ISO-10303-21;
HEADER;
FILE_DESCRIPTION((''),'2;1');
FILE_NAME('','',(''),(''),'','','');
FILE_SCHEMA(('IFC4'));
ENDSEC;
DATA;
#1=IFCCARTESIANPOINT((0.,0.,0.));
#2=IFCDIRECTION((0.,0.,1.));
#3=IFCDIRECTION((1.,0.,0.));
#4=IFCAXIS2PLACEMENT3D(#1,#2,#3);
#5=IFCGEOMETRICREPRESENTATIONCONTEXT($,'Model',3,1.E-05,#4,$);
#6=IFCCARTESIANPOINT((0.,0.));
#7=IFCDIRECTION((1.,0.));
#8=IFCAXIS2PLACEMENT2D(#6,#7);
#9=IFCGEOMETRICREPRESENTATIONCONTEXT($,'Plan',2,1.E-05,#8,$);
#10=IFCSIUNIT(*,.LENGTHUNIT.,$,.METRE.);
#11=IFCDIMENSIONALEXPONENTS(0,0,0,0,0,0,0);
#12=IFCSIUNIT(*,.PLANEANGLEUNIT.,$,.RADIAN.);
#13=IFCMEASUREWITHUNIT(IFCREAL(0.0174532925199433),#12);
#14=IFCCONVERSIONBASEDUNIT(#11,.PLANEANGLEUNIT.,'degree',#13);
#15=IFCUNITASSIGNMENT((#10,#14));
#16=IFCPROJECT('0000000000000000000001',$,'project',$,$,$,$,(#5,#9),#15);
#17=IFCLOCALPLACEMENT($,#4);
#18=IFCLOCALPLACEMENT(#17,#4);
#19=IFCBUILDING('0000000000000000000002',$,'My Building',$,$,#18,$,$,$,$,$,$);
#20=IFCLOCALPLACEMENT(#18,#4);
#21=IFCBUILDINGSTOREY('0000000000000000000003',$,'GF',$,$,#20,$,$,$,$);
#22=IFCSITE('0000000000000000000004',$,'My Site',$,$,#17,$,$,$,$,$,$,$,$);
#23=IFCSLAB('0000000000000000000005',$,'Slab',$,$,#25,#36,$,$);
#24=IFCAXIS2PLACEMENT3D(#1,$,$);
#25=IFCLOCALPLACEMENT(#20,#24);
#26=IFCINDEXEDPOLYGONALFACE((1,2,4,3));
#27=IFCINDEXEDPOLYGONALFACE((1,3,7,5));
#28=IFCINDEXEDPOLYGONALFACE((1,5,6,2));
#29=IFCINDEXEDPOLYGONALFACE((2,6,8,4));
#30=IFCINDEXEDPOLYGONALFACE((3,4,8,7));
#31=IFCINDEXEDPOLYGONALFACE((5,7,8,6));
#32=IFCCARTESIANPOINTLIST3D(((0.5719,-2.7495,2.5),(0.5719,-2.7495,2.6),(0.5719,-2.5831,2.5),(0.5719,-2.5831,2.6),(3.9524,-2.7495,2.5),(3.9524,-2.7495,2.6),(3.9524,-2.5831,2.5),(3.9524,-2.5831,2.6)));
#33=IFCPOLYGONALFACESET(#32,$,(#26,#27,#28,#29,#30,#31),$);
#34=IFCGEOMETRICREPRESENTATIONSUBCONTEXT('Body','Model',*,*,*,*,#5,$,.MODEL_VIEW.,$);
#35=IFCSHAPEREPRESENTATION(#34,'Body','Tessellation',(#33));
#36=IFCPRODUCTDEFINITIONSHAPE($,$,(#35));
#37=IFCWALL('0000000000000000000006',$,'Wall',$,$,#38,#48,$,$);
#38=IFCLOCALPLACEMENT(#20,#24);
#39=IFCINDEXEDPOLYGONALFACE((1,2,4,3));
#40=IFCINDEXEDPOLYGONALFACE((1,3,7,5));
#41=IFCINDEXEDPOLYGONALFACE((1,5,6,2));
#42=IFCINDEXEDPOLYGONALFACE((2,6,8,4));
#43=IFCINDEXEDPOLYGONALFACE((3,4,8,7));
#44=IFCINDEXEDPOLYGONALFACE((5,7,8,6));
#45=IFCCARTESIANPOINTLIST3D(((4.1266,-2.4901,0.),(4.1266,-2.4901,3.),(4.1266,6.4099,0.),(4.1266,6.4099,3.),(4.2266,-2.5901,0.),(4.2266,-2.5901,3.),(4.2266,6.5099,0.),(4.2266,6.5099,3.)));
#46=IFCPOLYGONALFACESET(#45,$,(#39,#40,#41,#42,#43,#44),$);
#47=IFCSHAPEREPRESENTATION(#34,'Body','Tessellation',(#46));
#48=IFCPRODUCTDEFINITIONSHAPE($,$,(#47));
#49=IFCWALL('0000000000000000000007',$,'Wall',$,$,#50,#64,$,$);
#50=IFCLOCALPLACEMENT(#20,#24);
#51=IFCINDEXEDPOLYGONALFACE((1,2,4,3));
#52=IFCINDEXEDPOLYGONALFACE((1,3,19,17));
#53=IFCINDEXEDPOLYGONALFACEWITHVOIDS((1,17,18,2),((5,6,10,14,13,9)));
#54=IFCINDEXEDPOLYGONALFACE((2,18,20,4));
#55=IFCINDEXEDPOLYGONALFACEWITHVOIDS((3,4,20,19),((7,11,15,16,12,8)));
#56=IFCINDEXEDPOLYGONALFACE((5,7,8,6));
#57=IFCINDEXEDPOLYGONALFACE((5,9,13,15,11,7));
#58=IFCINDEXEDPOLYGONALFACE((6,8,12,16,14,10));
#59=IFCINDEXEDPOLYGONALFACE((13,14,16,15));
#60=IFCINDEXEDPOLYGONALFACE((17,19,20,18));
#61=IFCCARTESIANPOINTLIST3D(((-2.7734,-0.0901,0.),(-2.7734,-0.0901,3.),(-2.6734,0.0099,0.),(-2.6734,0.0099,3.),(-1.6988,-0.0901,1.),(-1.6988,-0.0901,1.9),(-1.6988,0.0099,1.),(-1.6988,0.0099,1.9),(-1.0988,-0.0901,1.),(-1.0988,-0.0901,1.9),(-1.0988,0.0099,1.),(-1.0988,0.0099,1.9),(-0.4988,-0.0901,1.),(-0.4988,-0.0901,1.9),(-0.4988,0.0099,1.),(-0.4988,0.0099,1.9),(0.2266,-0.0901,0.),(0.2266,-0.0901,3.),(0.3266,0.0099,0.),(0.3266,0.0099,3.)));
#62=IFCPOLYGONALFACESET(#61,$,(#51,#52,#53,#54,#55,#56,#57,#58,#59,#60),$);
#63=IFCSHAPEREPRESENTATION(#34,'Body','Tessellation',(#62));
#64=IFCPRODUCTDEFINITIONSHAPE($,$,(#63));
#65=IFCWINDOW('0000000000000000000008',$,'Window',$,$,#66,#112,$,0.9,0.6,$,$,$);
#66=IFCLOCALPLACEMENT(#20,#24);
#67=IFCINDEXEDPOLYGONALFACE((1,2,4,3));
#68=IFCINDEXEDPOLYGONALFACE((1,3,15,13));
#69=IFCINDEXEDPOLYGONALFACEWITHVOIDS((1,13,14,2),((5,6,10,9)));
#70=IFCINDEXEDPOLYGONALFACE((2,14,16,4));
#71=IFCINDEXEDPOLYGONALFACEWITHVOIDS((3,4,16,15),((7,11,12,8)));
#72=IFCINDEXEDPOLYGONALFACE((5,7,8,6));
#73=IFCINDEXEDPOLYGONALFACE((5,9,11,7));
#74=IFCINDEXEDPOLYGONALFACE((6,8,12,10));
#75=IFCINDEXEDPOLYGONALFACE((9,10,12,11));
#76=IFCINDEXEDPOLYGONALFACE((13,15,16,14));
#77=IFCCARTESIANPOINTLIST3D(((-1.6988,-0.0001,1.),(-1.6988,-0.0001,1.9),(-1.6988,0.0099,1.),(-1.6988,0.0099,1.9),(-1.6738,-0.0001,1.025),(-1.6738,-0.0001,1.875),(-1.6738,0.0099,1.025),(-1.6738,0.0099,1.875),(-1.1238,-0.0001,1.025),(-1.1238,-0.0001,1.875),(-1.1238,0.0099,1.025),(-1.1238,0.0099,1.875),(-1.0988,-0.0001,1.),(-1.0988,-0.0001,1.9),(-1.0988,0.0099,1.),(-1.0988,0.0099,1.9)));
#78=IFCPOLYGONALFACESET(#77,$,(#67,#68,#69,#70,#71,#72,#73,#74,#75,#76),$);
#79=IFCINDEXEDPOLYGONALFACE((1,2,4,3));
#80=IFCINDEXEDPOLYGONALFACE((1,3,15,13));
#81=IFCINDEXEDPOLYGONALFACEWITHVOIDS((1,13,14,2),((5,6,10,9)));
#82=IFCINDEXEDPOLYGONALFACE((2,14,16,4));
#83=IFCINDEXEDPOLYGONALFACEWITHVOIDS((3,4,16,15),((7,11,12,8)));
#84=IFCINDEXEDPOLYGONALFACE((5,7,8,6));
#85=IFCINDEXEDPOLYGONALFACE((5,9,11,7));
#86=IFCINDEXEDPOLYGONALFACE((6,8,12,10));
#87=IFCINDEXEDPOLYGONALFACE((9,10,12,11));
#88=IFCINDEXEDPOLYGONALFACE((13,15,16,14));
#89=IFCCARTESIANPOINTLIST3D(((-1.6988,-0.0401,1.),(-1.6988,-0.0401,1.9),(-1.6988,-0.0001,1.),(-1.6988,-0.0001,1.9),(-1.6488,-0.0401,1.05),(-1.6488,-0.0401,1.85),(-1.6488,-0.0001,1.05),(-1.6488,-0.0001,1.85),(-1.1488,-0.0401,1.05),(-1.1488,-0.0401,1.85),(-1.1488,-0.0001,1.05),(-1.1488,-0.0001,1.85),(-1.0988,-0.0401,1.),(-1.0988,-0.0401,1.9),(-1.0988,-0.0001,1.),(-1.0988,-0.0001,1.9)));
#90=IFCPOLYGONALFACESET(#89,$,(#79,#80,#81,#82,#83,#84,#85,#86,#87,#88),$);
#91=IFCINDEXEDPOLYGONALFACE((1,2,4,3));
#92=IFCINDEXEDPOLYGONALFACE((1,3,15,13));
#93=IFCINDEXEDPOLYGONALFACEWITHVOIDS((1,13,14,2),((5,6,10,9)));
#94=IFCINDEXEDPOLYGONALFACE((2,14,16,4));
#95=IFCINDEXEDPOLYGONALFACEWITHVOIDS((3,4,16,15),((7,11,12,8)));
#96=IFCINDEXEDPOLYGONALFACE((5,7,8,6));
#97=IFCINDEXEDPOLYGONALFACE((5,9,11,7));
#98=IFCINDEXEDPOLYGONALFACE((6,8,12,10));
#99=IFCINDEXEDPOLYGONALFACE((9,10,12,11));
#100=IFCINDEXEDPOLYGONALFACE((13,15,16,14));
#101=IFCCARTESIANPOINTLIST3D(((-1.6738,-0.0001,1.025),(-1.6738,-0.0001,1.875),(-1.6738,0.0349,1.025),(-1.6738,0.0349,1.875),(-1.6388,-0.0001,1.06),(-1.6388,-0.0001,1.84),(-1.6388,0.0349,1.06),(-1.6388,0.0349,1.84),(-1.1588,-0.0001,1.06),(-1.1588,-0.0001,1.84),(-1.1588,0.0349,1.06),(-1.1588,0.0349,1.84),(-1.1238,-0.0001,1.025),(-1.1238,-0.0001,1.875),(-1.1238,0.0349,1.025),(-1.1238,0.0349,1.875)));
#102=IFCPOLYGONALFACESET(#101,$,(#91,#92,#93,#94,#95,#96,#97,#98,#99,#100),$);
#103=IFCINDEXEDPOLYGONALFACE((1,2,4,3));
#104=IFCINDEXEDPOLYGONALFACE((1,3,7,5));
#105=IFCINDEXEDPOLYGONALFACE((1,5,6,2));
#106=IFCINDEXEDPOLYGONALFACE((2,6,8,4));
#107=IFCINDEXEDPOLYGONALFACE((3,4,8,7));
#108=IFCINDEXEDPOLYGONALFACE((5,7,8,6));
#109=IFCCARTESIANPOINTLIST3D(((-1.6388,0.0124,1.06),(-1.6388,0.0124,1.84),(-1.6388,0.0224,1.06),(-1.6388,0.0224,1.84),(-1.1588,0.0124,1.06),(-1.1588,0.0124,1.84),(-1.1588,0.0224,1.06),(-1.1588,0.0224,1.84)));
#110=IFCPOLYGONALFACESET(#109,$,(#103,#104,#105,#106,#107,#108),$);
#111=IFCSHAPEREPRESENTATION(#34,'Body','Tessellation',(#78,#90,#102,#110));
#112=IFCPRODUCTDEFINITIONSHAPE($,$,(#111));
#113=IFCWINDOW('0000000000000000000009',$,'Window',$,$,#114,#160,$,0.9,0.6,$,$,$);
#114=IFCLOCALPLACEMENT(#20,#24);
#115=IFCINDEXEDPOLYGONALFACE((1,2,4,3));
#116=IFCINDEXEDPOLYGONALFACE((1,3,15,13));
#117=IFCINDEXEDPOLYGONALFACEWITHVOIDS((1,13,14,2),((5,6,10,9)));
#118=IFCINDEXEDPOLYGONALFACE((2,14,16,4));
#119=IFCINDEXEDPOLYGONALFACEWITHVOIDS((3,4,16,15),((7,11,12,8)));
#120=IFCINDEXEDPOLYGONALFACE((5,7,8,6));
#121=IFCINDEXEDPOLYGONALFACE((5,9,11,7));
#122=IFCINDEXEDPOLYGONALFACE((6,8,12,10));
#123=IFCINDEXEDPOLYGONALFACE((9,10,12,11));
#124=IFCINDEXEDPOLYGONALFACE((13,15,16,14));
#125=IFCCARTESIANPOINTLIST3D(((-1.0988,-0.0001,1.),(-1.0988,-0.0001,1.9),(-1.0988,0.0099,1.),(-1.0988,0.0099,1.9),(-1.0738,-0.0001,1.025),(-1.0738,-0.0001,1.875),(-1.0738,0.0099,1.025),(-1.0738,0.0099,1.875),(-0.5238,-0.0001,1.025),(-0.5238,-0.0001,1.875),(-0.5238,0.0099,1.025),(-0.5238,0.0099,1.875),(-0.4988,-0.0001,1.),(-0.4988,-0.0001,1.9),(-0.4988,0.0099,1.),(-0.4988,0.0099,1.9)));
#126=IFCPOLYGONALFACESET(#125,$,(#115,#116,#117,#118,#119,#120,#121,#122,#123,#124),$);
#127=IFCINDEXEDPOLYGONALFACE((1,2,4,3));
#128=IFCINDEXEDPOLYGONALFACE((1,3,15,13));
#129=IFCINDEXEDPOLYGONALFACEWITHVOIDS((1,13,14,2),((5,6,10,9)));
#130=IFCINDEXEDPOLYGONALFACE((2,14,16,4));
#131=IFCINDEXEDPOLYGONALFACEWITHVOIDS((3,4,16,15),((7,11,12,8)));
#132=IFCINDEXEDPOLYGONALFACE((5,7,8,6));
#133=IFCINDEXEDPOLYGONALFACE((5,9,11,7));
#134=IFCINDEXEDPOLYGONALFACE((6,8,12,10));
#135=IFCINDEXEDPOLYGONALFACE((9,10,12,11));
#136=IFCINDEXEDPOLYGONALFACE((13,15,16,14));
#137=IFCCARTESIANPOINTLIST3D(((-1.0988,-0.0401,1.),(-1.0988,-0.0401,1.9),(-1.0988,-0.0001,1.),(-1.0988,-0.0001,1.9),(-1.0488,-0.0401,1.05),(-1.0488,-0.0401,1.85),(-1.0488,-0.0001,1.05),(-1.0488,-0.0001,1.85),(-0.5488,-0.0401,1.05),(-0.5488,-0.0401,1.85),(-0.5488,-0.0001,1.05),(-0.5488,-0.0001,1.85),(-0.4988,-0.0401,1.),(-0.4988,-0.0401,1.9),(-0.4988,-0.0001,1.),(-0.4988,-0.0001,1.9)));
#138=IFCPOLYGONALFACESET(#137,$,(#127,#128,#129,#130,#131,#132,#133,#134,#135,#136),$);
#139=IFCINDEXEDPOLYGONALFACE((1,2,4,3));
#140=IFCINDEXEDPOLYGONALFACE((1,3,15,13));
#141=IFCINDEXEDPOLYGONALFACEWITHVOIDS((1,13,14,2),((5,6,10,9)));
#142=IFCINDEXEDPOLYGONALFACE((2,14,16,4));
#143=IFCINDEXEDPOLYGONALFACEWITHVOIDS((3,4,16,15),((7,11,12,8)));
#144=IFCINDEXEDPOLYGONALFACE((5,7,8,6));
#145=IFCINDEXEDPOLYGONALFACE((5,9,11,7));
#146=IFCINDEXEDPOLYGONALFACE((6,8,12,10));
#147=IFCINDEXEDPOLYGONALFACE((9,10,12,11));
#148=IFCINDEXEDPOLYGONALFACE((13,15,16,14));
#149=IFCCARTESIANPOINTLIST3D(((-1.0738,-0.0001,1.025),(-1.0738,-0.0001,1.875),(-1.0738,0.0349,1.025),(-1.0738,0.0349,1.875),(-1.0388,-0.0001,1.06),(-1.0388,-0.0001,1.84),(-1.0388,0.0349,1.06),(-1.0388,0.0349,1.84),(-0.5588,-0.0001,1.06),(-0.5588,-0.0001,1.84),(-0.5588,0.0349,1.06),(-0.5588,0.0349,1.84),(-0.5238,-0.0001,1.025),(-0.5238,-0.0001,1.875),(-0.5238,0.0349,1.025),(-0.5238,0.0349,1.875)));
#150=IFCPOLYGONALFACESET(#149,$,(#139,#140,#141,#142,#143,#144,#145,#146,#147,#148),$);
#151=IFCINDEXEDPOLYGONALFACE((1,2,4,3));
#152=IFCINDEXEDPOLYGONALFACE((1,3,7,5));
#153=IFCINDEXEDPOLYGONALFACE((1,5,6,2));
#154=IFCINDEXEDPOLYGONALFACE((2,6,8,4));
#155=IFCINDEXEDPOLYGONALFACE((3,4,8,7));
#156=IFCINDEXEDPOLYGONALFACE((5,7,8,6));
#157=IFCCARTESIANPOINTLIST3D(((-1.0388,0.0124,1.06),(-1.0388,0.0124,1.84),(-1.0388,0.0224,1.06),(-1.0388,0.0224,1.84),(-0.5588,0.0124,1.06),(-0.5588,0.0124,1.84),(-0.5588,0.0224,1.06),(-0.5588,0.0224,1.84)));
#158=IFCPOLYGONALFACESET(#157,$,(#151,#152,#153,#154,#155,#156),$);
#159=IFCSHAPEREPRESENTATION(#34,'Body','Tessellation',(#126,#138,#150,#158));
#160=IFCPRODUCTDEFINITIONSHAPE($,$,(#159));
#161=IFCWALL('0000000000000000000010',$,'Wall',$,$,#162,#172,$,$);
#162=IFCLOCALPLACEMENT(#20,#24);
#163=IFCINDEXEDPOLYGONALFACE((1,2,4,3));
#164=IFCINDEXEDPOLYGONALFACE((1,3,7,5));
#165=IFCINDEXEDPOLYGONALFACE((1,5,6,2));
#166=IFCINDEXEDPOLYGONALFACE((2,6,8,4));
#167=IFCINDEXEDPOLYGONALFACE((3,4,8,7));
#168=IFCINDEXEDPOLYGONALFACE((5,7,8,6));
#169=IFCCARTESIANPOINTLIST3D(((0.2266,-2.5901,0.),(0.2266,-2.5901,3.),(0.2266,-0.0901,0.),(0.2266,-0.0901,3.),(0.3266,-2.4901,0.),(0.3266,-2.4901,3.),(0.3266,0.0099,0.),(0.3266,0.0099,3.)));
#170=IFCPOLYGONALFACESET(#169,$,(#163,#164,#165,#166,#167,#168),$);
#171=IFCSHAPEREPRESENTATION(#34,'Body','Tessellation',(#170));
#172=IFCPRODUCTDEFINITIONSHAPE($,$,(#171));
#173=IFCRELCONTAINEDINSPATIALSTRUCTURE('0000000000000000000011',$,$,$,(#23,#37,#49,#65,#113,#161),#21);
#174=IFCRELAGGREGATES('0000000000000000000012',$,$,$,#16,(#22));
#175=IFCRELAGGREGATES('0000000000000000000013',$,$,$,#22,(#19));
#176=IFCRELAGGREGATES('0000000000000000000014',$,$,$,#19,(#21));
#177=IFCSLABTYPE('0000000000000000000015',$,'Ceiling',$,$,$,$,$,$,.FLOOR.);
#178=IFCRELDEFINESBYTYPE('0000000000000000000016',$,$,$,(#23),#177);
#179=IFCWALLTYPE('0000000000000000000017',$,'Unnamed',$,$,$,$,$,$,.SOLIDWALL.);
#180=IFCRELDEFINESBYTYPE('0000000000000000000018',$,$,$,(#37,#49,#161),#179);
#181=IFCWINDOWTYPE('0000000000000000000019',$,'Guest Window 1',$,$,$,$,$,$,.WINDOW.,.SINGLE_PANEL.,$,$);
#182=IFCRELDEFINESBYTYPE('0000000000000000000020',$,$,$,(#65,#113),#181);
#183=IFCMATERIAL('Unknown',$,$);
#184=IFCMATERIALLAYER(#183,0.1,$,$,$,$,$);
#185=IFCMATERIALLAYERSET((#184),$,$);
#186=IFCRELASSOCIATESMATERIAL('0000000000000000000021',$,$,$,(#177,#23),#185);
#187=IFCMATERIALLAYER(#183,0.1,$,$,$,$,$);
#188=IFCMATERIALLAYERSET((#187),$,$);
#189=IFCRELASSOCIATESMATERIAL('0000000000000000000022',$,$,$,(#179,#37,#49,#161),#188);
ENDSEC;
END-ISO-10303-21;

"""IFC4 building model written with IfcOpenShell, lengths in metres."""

from ifc_helpers import new_model, entity, si_unit, converted_unit, frame, origin_with_axes, origin_2d_with_axis, place, context, subcontext, project, spatial, line, indexed_curve, outline, extrude, shape, source, transform, mapped, material, layer, layer_set, layer_usage, type_object, type_shapes, element, fill, save


model = new_model("IFC4")

# Units and contexts
model_context = context("Model", 3, precision=1e-05, world=origin_with_axes())
plan_context = context("Plan", 2, precision=1e-05, world=origin_2d_with_axis())
body_context_1 = subcontext(model_context, "Body", "Model", "MODEL_VIEW")
body_context_2 = subcontext(plan_context, "Body", "Plan", "PLAN_VIEW")
ifc_project = project(units=[si_unit("LENGTHUNIT", "METRE"), converted_unit("PLANEANGLEUNIT", "degree", entity("IfcReal", 0.0174532925199433), si_unit("PLANEANGLEUNIT", "RADIAN"), dimensions=[0, 0, 0, 0, 0, 0, 0])], contexts=[model_context, plan_context])

# Site, building, storey
site_placement = place(None, origin_with_axes())
site = spatial("IfcSite", under=ifc_project, at=site_placement, Name="My Site")
building_placement = place(site_placement, origin_with_axes())
building = spatial("IfcBuilding", under=site, at=building_placement, Name="My Building")
storey_placement = place(building_placement, origin_with_axes())
storey = spatial("IfcBuildingStorey", under=building, at=storey_placement, Name="GF")

# Shared definitions
ifc_material = material(Name="Unknown")

# Slab
ifc_layer_1 = layer(ifc_material, 0.1)
ifc_layer_set_1 = layer_set([ifc_layer_1])
ifc_layer_usage_1 = layer_usage(ifc_layer_set_1, "AXIS3", "POSITIVE", -0.1)
slab_type_1 = type_object("IfcSlabType", Name="Ceiling", PredefinedType="FLOOR", material=ifc_layer_set_1)
slab_1_placement = place(storey_placement, frame((3.9524, -2.7495, 2.6), z_axis=(0.0, 0.0, 1.0), x_axis=(1.0, 0.0, 0.0)))
element("IfcSlab", 1, at=slab_1_placement, inside=storey, type_object=slab_type_1, material=ifc_layer_usage_1, Name="Slab", context=body_context_1, shape_type="SweptSolid", body=[
    extrude(outline(indexed_curve([(0.0, 0.0), (0.0, 0.1665), (-3.3805, 0.1665), (-3.3805, 0.0), (0.0001, 0.0), (0.0, 0.0)])), frame((0.0, 0.0, -0.1), z_axis=(0.0, 0.0, 1.0), x_axis=(1.0, 0.0, 0.0)), (0.0, 0.0, 1.0), 0.1),
])

# Shared definitions
ifc_layer_2 = layer(ifc_material, 0.1)
ifc_layer_set_2 = layer_set([ifc_layer_2])
wall_type = type_object("IfcWallType", Name="Unnamed", PredefinedType="SOLIDWALL", material=ifc_layer_set_2)

# Wall
ifc_layer_usage_2 = layer_usage(ifc_layer_set_2, "AXIS2", "POSITIVE", 0.0)
wall_1_placement = place(storey_placement, frame((4.2266, -2.5901, 0.0), z_axis=(0.0, 0.0, 1.0), x_axis=(0.0, 1.0, 0.0)))
element("IfcWall", 2, at=wall_1_placement, inside=storey, type_object=wall_type, material=ifc_layer_usage_2, Name="Wall", context=body_context_1, shape_type="SweptSolid", body=[
    extrude(outline(indexed_curve([(0.0, 0.0), (0.1, 0.1), (9.0, 0.1), (9.1, 0.0)], segments=[line(1, 2, 3, 4, 1)])), origin_with_axes(), (0.0, 0.0, 1.0), 3.0),
])

# Wall, openings, windows
ifc_layer_usage_3 = layer_usage(ifc_layer_set_2, "AXIS2", "POSITIVE", 0.0)
wall_2_placement = place(storey_placement, frame((-2.7734, -0.0901, 0.0), z_axis=(0.0, 0.0, 1.0), x_axis=(1.0, 0.0, 0.0)))
wall_2 = element("IfcWall", 3, at=wall_2_placement, inside=storey, type_object=wall_type, material=ifc_layer_usage_3, Name="Wall", context=body_context_1, shape_type="SweptSolid", body=[
    extrude(outline(indexed_curve([(0.0, 0.0), (0.1, 0.1), (3.1, 0.1), (3.0, 0.0)], segments=[line(1, 2, 3, 4, 1)])), origin_with_axes(), (0.0, 0.0, 1.0), 3.0),
])
shared_shape_1 = source(origin_with_axes(), body_context_1, "Body", "SweptSolid", [
    extrude(outline(indexed_curve([(0.0, 0.0), (0.6, 0.0), (0.6, 0.9), (0.0, 0.9)], segments=[line(1, 2, 3, 4, 1)])), frame((0.0, -0.6, 0.0), z_axis=(0.0, -1.0, 0.0), x_axis=(1.0, 0.0, 0.0)), (0.0, 0.0, -1.0), 1.2),
])
opening_1_placement = place(wall_2_placement, frame((1.0746, 0.0, 1.0), z_axis=(0.0, 0.0, 1.0), x_axis=(1.0, 0.0, 0.0)))
opening_1 = element("IfcOpeningElement", 4, at=opening_1_placement, cuts=wall_2, PredefinedType="OPENING", context=body_context_1, shape_type="MappedRepresentation", body=[
    mapped(shared_shape_1, transform((0.0, 0.0, 0.0), x_axis=(1.0, 0.0, 0.0), y_axis=(0.0, 1.0, 0.0), z_axis=(0.0, 0.0, 1.0), scale=1.0)),
])
opening_2_placement = place(wall_2_placement, frame((1.6746, 0.0, 1.0), z_axis=(0.0, 0.0, 1.0), x_axis=(1.0, 0.0, 0.0)))
opening_2 = element("IfcOpeningElement", 5, at=opening_2_placement, cuts=wall_2, PredefinedType="OPENING", context=body_context_1, shape_type="MappedRepresentation", body=[
    mapped(shared_shape_1, transform((0.0, 0.0, 0.0), x_axis=(1.0, 0.0, 0.0), y_axis=(0.0, 1.0, 0.0), z_axis=(0.0, 0.0, 1.0), scale=1.0)),
])
window_type_1 = type_object("IfcWindowType", Name="Guest Window 1", PartitioningType="SINGLE_PANEL", PredefinedType="WINDOW")
shared_shape_2 = source(origin_with_axes(), body_context_1, "Body", "SweptSolid", [
    extrude(outline(indexed_curve([(0.0, 0.0), (0.6, 0.0), (0.6, 0.9), (0.0, 0.9)], segments=[line(1, 2, 3, 4, 1)]), holes=[indexed_curve([(0.025, 0.025), (0.575, 0.025), (0.575, 0.875), (0.025, 0.875)], segments=[line(1, 2, 3, 4, 1)])]), frame((0.0, 0.09, 0.0), z_axis=(0.0, -1.0, 0.0), x_axis=(1.0, 0.0, 0.0)), (0.0, 0.0, -1.0), 0.01),
    extrude(outline(indexed_curve([(0.0, 0.0), (0.6, 0.0), (0.6, 0.9), (0.0, 0.9)], segments=[line(1, 2, 3, 4, 1)]), holes=[indexed_curve([(0.05, 0.05), (0.55, 0.05), (0.55, 0.85), (0.05, 0.85)], segments=[line(1, 2, 3, 4, 1)])]), frame((0.0, 0.05, 0.0), z_axis=(0.0, -1.0, 0.0), x_axis=(1.0, 0.0, 0.0)), (0.0, 0.0, -1.0), 0.04),
    extrude(outline(indexed_curve([(0.0, 0.0), (0.55, 0.0), (0.55, 0.85), (0.0, 0.85)], segments=[line(1, 2, 3, 4, 1)]), holes=[indexed_curve([(0.035, 0.035), (0.515, 0.035), (0.515, 0.815), (0.035, 0.815)], segments=[line(1, 2, 3, 4, 1)])]), frame((0.025, 0.09, 0.025), z_axis=(0.0, -1.0, 0.0), x_axis=(1.0, 0.0, 0.0)), (0.0, 0.0, -1.0), 0.035),
    extrude(outline(indexed_curve([(0.035, 0.035), (0.515, 0.035), (0.515, 0.815), (0.035, 0.815)], segments=[line(1, 2, 3, 4, 1)])), frame((0.025, 0.1025, 0.025), z_axis=(0.0, -1.0, 0.0), x_axis=(1.0, 0.0, 0.0)), (0.0, 0.0, -1.0), 0.01),
])
shared_shape_3 = source(origin_with_axes(), body_context_2, "Body", "Curve2D", [
    entity("IfcIndexedPolyCurve", entity("IfcCartesianPointList2D", [[0.05, 0.05], [0.55, 0.05]])),
    entity("IfcIndexedPolyCurve", entity("IfcCartesianPointList2D", [[0.0, 0.1], [0.025, 0.1], [0.025, 0.09], [0.05, 0.09], [0.05, 0.05], [0.0, 0.05]]), [entity("IfcLineIndex", [1, 2, 3, 4, 5, 6, 1])]),
    entity("IfcIndexedPolyCurve", entity("IfcCartesianPointList2D", [[0.6, 0.1], [0.575, 0.1], [0.575, 0.09], [0.55, 0.09], [0.55, 0.05], [0.6, 0.05]]), [entity("IfcLineIndex", [1, 2, 3, 4, 5, 6, 1])]),
    entity("IfcIndexedPolyCurve", entity("IfcCartesianPointList2D", [[0.025, 0.09], [0.06, 0.09], [0.06, 0.125], [0.025, 0.125]]), [entity("IfcLineIndex", [1, 2, 3, 4, 1])]),
    entity("IfcIndexedPolyCurve", entity("IfcCartesianPointList2D", [[0.575, 0.09], [0.54, 0.09], [0.54, 0.125], [0.575, 0.125]]), [entity("IfcLineIndex", [1, 2, 3, 4, 1])]),
    entity("IfcIndexedPolyCurve", entity("IfcCartesianPointList2D", [[0.06, 0.09], [0.54, 0.09]])),
    entity("IfcIndexedPolyCurve", entity("IfcCartesianPointList2D", [[0.06, 0.125], [0.54, 0.125]])),
    entity("IfcIndexedPolyCurve", entity("IfcCartesianPointList2D", [[0.06, 0.1075], [0.54, 0.1075]])),
])
type_shapes(window_type_1, [shared_shape_2, shared_shape_3])
window_1_placement = place(opening_1_placement, origin_with_axes())
window_1 = element("IfcWindow", 6, at=window_1_placement, inside=storey, type_object=window_type_1, Name="Window", OverallHeight=0.9, OverallWidth=0.6, shapes=[
    shape(body_context_1, "Body", "MappedRepresentation", [mapped(shared_shape_2, transform((0.0, 0.0, 0.0), x_axis=(1.0, 0.0, 0.0), y_axis=(0.0, 1.0, 0.0), z_axis=(0.0, 0.0, 1.0), scale=1.0))]),
    shape(body_context_2, "Body", "MappedRepresentation", [mapped(shared_shape_3, transform((0.0, 0.0, 0.0), x_axis=(1.0, 0.0, 0.0), y_axis=(0.0, 1.0, 0.0), z_axis=(0.0, 0.0, 1.0), scale=1.0))]),
])
fill(opening_1, window_1)
window_2_placement = place(opening_2_placement, origin_with_axes())
window_2 = element("IfcWindow", 7, at=window_2_placement, inside=storey, type_object=window_type_1, Name="Window", OverallHeight=0.9, OverallWidth=0.6, shapes=[
    shape(body_context_1, "Body", "MappedRepresentation", [mapped(shared_shape_2, transform((0.0, 0.0, 0.0), x_axis=(1.0, 0.0, 0.0), y_axis=(0.0, 1.0, 0.0), z_axis=(0.0, 0.0, 1.0), scale=1.0))]),
    shape(body_context_2, "Body", "MappedRepresentation", [mapped(shared_shape_3, transform((0.0, 0.0, 0.0), x_axis=(1.0, 0.0, 0.0), y_axis=(0.0, 1.0, 0.0), z_axis=(0.0, 0.0, 1.0), scale=1.0))]),
])
fill(opening_2, window_2)

# Wall
ifc_layer_usage_4 = layer_usage(ifc_layer_set_2, "AXIS2", "POSITIVE", 0.0)
wall_3_placement = place(storey_placement, frame((0.2266, -0.0901, 0.0), z_axis=(0.0, 0.0, 1.0), x_axis=(0.0, -1.0, 0.0)))
element("IfcWall", 8, at=wall_3_placement, inside=storey, type_object=wall_type, material=ifc_layer_usage_4, Name="Wall", context=body_context_1, shape_type="SweptSolid", body=[
    extrude(outline(indexed_curve([(0.0, 0.0), (-0.1, 0.1), (2.4, 0.1), (2.5, 0.0)], segments=[line(1, 2, 3, 4, 1)])), origin_with_axes(), (0.0, 0.0, 1.0), 3.0),
])

save(model, "model.ifc")
